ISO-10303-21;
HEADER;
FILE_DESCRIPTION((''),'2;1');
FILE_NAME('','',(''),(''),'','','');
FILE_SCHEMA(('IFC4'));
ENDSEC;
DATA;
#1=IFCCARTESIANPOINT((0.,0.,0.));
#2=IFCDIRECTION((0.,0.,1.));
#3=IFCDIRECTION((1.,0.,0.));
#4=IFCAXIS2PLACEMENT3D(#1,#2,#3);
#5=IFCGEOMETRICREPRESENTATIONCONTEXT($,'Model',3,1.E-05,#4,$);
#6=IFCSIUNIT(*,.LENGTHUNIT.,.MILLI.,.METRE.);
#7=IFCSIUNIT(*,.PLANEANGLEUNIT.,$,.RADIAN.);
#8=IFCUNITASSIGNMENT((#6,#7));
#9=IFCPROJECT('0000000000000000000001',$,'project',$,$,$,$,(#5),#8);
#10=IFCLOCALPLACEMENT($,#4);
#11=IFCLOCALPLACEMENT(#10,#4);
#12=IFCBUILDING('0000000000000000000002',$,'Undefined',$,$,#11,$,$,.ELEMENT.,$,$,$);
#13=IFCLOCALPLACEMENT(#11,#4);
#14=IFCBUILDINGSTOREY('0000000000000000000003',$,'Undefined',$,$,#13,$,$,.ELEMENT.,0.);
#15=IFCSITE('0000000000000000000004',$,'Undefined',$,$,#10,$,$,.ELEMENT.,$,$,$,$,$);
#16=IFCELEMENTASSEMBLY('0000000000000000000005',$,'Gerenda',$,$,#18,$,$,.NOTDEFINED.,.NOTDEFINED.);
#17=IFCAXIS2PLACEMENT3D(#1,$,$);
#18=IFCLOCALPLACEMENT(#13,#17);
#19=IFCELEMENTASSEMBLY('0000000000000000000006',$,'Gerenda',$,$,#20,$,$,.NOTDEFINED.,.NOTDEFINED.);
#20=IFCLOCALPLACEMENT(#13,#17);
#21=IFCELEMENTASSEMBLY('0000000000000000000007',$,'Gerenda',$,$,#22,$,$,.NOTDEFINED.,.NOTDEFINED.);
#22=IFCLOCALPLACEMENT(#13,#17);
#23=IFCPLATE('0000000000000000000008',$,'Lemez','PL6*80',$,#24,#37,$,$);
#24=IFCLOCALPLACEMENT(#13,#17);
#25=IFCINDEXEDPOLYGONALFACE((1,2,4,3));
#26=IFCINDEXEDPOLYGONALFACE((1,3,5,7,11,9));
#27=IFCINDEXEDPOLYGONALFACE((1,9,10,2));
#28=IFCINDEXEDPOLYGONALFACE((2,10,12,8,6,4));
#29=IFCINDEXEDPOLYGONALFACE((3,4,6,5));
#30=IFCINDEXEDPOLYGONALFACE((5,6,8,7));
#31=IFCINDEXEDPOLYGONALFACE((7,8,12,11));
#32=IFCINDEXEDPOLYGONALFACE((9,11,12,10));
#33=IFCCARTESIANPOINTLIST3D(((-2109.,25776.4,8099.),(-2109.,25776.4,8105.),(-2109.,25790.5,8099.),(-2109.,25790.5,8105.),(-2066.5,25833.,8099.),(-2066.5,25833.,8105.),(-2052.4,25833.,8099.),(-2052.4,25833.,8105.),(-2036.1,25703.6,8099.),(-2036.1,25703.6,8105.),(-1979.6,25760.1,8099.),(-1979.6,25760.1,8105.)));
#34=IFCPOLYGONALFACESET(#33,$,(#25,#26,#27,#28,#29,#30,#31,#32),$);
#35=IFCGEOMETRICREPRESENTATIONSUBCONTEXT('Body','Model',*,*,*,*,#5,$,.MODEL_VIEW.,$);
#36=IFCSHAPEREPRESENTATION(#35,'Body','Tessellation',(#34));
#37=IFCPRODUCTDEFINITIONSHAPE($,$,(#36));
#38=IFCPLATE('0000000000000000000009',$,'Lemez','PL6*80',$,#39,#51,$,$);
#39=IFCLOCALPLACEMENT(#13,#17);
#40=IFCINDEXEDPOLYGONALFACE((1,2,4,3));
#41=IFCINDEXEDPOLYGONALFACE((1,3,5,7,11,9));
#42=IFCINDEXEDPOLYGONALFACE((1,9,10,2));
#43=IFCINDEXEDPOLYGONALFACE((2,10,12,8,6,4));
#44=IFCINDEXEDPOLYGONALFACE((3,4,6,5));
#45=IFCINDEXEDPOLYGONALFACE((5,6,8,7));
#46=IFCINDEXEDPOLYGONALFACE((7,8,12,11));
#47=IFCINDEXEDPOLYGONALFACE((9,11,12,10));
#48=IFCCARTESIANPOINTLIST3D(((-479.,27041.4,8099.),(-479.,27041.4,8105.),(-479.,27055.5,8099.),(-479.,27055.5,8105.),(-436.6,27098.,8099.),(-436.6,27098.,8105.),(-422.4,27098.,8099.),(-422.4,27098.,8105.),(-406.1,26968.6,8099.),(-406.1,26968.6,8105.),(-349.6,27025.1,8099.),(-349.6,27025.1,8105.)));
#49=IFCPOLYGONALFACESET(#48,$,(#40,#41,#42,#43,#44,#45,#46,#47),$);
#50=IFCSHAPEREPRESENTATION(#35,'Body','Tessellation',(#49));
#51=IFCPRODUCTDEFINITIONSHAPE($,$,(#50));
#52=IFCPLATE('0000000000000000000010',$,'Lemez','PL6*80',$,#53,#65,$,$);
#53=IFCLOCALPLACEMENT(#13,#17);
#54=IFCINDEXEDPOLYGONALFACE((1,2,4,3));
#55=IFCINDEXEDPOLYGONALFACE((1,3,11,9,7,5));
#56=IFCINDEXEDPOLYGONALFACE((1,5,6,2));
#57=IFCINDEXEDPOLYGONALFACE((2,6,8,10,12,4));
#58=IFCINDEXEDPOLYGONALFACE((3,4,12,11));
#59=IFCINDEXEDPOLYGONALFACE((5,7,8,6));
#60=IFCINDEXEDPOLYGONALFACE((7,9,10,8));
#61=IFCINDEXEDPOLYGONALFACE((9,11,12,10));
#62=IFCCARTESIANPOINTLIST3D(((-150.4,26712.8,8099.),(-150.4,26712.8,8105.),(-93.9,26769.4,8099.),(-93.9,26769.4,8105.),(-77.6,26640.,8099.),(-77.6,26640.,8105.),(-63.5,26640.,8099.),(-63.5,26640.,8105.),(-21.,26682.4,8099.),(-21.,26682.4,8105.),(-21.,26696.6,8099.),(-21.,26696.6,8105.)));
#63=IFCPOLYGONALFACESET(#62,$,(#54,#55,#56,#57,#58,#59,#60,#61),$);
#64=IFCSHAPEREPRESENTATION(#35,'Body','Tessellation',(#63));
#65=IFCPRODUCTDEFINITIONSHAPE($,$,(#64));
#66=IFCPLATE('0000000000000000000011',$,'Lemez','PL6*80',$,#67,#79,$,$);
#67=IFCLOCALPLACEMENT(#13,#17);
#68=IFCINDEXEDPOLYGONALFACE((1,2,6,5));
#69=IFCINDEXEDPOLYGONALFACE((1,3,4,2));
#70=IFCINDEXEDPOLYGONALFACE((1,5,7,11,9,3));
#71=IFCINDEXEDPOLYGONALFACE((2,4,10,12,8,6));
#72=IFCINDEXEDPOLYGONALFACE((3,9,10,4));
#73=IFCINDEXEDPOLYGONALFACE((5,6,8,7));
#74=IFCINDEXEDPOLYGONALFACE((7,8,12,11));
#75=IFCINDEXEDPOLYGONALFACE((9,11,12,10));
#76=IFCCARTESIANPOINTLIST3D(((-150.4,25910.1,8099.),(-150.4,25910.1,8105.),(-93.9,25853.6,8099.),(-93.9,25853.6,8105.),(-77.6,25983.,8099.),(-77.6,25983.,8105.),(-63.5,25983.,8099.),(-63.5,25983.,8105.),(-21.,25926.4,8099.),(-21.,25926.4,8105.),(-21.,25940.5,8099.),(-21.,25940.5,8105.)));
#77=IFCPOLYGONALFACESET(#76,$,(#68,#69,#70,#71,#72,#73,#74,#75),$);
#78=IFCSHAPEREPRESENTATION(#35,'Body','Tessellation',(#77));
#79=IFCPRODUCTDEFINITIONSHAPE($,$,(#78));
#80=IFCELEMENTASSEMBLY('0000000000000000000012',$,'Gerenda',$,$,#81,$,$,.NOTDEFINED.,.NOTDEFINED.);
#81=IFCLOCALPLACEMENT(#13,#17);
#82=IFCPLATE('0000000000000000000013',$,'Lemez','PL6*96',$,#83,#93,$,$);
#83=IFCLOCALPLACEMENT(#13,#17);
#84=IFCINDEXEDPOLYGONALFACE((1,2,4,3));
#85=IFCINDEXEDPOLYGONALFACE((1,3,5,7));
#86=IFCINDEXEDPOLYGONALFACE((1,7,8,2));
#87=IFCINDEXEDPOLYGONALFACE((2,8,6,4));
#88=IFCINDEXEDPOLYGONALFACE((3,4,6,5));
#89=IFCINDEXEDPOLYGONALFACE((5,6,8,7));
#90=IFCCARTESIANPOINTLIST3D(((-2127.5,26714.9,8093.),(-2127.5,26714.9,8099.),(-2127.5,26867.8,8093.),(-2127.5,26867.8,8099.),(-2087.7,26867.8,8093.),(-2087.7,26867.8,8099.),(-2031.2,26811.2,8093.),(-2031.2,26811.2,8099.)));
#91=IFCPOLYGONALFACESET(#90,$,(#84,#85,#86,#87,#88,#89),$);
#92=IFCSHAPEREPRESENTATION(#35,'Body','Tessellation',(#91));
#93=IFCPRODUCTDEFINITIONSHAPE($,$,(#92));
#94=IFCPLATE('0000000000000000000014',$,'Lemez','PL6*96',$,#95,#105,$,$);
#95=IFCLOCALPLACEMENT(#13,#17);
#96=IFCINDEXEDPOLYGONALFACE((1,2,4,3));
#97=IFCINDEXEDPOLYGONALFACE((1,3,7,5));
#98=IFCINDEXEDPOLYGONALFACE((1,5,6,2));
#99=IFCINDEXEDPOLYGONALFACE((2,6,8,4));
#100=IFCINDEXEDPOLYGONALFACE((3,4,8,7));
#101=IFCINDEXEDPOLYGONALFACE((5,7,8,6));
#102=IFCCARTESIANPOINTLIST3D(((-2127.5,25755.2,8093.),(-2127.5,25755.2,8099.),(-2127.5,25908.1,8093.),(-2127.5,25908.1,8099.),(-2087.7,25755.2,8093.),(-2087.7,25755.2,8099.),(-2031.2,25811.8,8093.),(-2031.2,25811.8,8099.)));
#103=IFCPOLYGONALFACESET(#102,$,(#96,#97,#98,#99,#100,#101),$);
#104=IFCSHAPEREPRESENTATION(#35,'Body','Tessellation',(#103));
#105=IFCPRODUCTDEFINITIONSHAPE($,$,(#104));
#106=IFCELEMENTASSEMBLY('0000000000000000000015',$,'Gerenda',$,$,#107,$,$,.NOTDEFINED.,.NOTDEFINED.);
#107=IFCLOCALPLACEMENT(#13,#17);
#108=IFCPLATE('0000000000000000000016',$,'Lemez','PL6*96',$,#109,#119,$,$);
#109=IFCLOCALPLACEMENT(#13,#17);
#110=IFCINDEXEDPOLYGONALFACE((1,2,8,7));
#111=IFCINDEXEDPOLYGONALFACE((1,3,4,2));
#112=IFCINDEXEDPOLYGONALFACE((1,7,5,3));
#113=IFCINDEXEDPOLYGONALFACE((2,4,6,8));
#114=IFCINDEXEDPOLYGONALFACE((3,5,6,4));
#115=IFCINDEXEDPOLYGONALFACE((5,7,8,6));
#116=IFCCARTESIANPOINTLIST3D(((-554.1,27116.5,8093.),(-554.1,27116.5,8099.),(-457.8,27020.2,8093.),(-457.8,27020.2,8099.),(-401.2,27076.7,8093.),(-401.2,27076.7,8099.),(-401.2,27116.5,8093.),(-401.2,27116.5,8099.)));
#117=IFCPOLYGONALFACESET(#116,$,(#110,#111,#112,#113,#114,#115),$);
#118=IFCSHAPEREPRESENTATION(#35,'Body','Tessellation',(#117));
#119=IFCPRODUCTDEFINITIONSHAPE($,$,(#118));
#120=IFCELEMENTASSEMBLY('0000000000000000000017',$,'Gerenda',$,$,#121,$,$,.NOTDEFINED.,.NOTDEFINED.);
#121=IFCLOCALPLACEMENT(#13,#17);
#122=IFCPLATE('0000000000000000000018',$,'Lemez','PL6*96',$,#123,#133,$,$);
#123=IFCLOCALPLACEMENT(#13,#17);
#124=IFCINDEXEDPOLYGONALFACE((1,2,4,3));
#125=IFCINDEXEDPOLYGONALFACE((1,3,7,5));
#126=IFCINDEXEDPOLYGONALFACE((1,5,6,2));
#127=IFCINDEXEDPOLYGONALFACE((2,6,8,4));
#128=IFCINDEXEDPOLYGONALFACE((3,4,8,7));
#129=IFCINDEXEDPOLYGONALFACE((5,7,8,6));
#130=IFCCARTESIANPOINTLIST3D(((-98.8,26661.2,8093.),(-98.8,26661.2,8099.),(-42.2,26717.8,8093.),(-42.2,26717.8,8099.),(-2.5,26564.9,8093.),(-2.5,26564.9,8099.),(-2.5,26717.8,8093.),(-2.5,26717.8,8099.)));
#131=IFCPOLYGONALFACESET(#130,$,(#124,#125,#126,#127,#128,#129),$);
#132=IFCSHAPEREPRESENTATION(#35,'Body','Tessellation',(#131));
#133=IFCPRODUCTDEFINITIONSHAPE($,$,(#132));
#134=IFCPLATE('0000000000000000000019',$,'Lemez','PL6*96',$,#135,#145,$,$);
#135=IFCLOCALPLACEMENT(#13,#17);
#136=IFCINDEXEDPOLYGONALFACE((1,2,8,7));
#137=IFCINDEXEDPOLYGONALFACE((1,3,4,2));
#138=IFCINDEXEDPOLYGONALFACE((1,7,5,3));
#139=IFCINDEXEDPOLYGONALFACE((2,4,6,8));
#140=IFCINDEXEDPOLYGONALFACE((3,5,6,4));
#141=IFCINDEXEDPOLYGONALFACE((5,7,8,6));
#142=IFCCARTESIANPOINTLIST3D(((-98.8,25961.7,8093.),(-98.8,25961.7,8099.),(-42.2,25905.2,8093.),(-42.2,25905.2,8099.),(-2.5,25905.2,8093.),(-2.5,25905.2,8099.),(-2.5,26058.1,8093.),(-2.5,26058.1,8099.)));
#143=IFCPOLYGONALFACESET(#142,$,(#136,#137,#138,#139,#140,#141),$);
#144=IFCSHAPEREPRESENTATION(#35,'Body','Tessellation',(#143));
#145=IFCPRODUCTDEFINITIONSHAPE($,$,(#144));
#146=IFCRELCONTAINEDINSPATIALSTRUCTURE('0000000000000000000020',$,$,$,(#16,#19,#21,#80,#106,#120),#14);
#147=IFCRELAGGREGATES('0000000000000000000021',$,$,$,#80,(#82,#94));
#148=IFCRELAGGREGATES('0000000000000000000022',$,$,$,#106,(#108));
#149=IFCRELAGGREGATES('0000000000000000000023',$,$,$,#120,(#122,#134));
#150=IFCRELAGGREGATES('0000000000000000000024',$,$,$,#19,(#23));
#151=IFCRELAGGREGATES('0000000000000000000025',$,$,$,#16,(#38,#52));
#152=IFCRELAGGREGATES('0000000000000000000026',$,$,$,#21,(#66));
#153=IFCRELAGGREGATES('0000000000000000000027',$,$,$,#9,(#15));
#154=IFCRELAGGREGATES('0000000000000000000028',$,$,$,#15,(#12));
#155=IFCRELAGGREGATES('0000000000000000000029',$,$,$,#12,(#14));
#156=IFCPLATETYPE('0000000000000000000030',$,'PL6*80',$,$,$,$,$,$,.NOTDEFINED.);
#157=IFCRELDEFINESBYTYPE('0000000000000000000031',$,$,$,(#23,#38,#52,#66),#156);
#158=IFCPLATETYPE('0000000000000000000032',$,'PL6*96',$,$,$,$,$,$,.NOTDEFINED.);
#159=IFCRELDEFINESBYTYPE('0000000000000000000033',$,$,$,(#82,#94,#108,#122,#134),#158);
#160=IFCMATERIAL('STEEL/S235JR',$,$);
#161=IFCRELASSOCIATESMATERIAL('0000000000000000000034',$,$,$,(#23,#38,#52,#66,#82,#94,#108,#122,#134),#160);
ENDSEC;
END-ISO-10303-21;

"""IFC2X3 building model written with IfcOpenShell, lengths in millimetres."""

from ifc_helpers import new_model, si_unit, frame, origin_with_axes, place, context, subcontext, project, spatial, polyline, outline, extrude, material, type_object, element, aggregate, save


model = new_model("IFC2X3")

# Units and contexts
model_context = context("Model", 3, precision=1e-05, world=origin_with_axes())
body_context = subcontext(model_context, "Body", "Model", "MODEL_VIEW")
ifc_project = project(units=[si_unit("LENGTHUNIT", "METRE", prefix="MILLI"), si_unit("PLANEANGLEUNIT", "RADIAN")], contexts=[model_context])

# Site, building, storey
site_placement = place(None, origin_with_axes())
site = spatial("IfcSite", under=ifc_project, at=site_placement, Name="Undefined", CompositionType="ELEMENT")
building_placement = place(site_placement, origin_with_axes())
building = spatial("IfcBuilding", under=site, at=building_placement, Name="Undefined", CompositionType="ELEMENT")
storey_placement = place(building_placement, origin_with_axes())
storey = spatial("IfcBuildingStorey", under=building, at=storey_placement, Name="Undefined", CompositionType="ELEMENT", Elevation=0.0)

# Element assembly
assembly_1_placement = place(storey_placement, origin_with_axes())
assembly_1 = element("IfcElementAssembly", 1, at=assembly_1_placement, inside=storey, Name="Gerenda", AssemblyPlace="NOTDEFINED", PredefinedType="NOTDEFINED")
ifc_material_1 = material(Name="STEEL/S235JR")

# Element assembly
assembly_2_placement = place(storey_placement, origin_with_axes())
assembly_2 = element("IfcElementAssembly", 2, at=assembly_2_placement, inside=storey, Name="Gerenda", AssemblyPlace="NOTDEFINED", PredefinedType="NOTDEFINED")

# Element assembly
assembly_3_placement = place(storey_placement, origin_with_axes())
assembly_3 = element("IfcElementAssembly", 3, at=assembly_3_placement, inside=storey, Name="Gerenda", AssemblyPlace="NOTDEFINED", PredefinedType="NOTDEFINED")

# Plates
plate_type_1 = type_object("IfcPlateType", Name="PL6*80", PredefinedType="NOTDEFINED")
plate_1_placement = place(assembly_2_placement, frame((-2052.4, 25833.0, 8102.0), z_axis=(0.0, 0.0, 1.0), x_axis=(-1.0, -0.000007, 0.0)))
plate_1 = element("IfcPlate", 4, at=plate_1_placement, type_object=plate_type_1, material=ifc_material_1, Name="Lemez", Description="PL6*80", context=body_context, shape_type="SweptSolid", body=[
    extrude(outline(polyline([(0.0, 0.0), (14.1, 0.0), (56.6, 42.4), (56.6, 56.6), (-16.3, 129.4), (-72.8, 72.8), (0.0, 0.0)])), frame((0.0, 0.0, -3.0), z_axis=(0.0, 0.0, 1.0), x_axis=(1.0, 0.0, 0.0)), (0.0, 0.0, 1.0), 6.0),
])
plate_2_placement = place(assembly_1_placement, frame((-422.4, 27098.0, 8102.0), z_axis=(0.0, 0.0, 1.0), x_axis=(-1.0, -0.000007, 0.0)))
plate_2 = element("IfcPlate", 5, at=plate_2_placement, type_object=plate_type_1, material=ifc_material_1, Name="Lemez", Description="PL6*80", context=body_context, shape_type="SweptSolid", body=[
    extrude(outline(polyline([(0.0, 0.0), (14.1, 0.0), (56.6, 42.4), (56.6, 56.6), (-16.3, 129.4), (-72.8, 72.8), (0.0, 0.0)])), frame((0.0, 0.0, -3.0), z_axis=(0.0, 0.0, 1.0), x_axis=(1.0, 0.0, 0.0)), (0.0, 0.0, 1.0), 6.0),
])
plate_3_placement = place(assembly_1_placement, frame((-77.6, 26640.0, 8102.0), z_axis=(0.0, 0.0, 1.0), x_axis=(1.0, 0.000007, 0.0)))
plate_3 = element("IfcPlate", 6, at=plate_3_placement, type_object=plate_type_1, material=ifc_material_1, Name="Lemez", Description="PL6*80", context=body_context, shape_type="SweptSolid", body=[
    extrude(outline(polyline([(0.0, 0.0), (14.1, 0.0), (56.6, 42.4), (56.6, 56.6), (-16.3, 129.4), (-72.8, 72.8), (0.0, 0.0)])), frame((0.0, 0.0, -3.0), z_axis=(0.0, 0.0, 1.0), x_axis=(1.0, 0.0, 0.0)), (0.0, 0.0, 1.0), 6.0),
])
plate_4_placement = place(assembly_3_placement, frame((-21.0, 25926.4, 8102.0), z_axis=(0.0, 0.0, 1.0), x_axis=(0.000007, 1.0, 0.0)))
plate_4 = element("IfcPlate", 7, at=plate_4_placement, type_object=plate_type_1, material=ifc_material_1, Name="Lemez", Description="PL6*80", context=body_context, shape_type="SweptSolid", body=[
    extrude(outline(polyline([(0.0, 0.0), (14.1, 0.0), (56.6, 42.4), (56.6, 56.6), (-16.3, 129.4), (-72.8, 72.8), (0.0, 0.0)])), frame((0.0, 0.0, -3.0), z_axis=(0.0, 0.0, 1.0), x_axis=(1.0, 0.0, 0.0)), (0.0, 0.0, 1.0), 6.0),
])

# Element assembly, plates
assembly_4_placement = place(storey_placement, origin_with_axes())
assembly_4 = element("IfcElementAssembly", 8, at=assembly_4_placement, inside=storey, Name="Gerenda", AssemblyPlace="NOTDEFINED", PredefinedType="NOTDEFINED")
plate_type_2 = type_object("IfcPlateType", Name="PL6*96", PredefinedType="NOTDEFINED")
plate_5_placement = place(assembly_4_placement, frame((-2127.5, 26867.8, 8096.0), z_axis=(0.0, 0.0, 1.0), x_axis=(-0.000004, -1.0, 0.0)))
plate_5 = element("IfcPlate", 9, at=plate_5_placement, type_object=plate_type_2, material=ifc_material_1, Name="Lemez", Description="PL6*96", context=body_context, shape_type="SweptSolid", body=[
    extrude(outline(polyline([(0.0, 0.0), (152.9, 0.0), (56.6, 96.3), (0.0, 39.7), (0.0, 0.0)])), frame((0.0, 0.0, -3.0), z_axis=(0.0, 0.0, 1.0), x_axis=(1.0, 0.0, 0.0)), (0.0, 0.0, 1.0), 6.0),
])
plate_6_placement = place(assembly_4_placement, frame((-2127.5, 25908.1, 8096.0), z_axis=(0.0, 0.0, 1.0), x_axis=(-0.000004, -1.0, 0.0)))
plate_6 = element("IfcPlate", 10, at=plate_6_placement, type_object=plate_type_2, material=ifc_material_1, Name="Lemez", Description="PL6*96", context=body_context, shape_type="SweptSolid", body=[
    extrude(outline(polyline([(0.0, 0.0), (152.9, 0.0), (152.9, 39.7), (96.3, 96.3), (0.0, 0.0)])), frame((0.0, 0.0, -3.0), z_axis=(0.0, 0.0, 1.0), x_axis=(1.0, 0.0, 0.0)), (0.0, 0.0, 1.0), 6.0),
])
aggregate(assembly_4, [plate_5, plate_6])

# Element assembly, plate
assembly_5_placement = place(storey_placement, origin_with_axes())
assembly_5 = element("IfcElementAssembly", 11, at=assembly_5_placement, inside=storey, Name="Gerenda", AssemblyPlace="NOTDEFINED", PredefinedType="NOTDEFINED")
plate_7_placement = place(assembly_5_placement, frame((-401.2, 27116.5, 8096.0), z_axis=(0.0, 0.0, 1.0), x_axis=(-1.0, 0.000003, 0.0)))
plate_7 = element("IfcPlate", 12, at=plate_7_placement, type_object=plate_type_2, material=ifc_material_1, Name="Lemez", Description="PL6*96", context=body_context, shape_type="SweptSolid", body=[
    extrude(outline(polyline([(0.0, 0.0), (152.9, 0.0), (56.6, 96.3), (0.0, 39.7), (0.0, 0.0)])), frame((0.0, 0.0, -3.0), z_axis=(0.0, 0.0, 1.0), x_axis=(1.0, 0.0, 0.0)), (0.0, 0.0, 1.0), 6.0),
])
aggregate(assembly_5, [plate_7])

# Element assembly, plates
assembly_6_placement = place(storey_placement, origin_with_axes())
assembly_6 = element("IfcElementAssembly", 13, at=assembly_6_placement, inside=storey, Name="Gerenda", AssemblyPlace="NOTDEFINED", PredefinedType="NOTDEFINED")
plate_8_placement = place(assembly_6_placement, frame((-2.5, 26564.9, 8096.0), z_axis=(0.0, 0.0, 1.0), x_axis=(0.000003, 1.0, 0.0)))
plate_8 = element("IfcPlate", 14, at=plate_8_placement, type_object=plate_type_2, material=ifc_material_1, Name="Lemez", Description="PL6*96", context=body_context, shape_type="SweptSolid", body=[
    extrude(outline(polyline([(0.0, 0.0), (152.9, 0.0), (152.9, 39.7), (96.3, 96.3), (0.0, 0.0)])), frame((0.0, 0.0, -3.0), z_axis=(0.0, 0.0, 1.0), x_axis=(1.0, 0.0, 0.0)), (0.0, 0.0, 1.0), 6.0),
])
plate_9_placement = place(assembly_6_placement, frame((-2.5, 25905.2, 8096.0), z_axis=(0.0, 0.0, 1.0), x_axis=(0.000003, 1.0, 0.0)))
plate_9 = element("IfcPlate", 15, at=plate_9_placement, type_object=plate_type_2, material=ifc_material_1, Name="Lemez", Description="PL6*96", context=body_context, shape_type="SweptSolid", body=[
    extrude(outline(polyline([(0.0, 0.0), (152.9, 0.0), (56.6, 96.3), (0.0, 39.7), (0.0, 0.0)])), frame((0.0, 0.0, -3.0), z_axis=(0.0, 0.0, 1.0), x_axis=(1.0, 0.0, 0.0)), (0.0, 0.0, 1.0), 6.0),
])
aggregate(assembly_6, [plate_8, plate_9])

aggregate(assembly_2, [plate_1])
aggregate(assembly_1, [plate_2, plate_3])
aggregate(assembly_3, [plate_4])

save(model, "model.ifc")
